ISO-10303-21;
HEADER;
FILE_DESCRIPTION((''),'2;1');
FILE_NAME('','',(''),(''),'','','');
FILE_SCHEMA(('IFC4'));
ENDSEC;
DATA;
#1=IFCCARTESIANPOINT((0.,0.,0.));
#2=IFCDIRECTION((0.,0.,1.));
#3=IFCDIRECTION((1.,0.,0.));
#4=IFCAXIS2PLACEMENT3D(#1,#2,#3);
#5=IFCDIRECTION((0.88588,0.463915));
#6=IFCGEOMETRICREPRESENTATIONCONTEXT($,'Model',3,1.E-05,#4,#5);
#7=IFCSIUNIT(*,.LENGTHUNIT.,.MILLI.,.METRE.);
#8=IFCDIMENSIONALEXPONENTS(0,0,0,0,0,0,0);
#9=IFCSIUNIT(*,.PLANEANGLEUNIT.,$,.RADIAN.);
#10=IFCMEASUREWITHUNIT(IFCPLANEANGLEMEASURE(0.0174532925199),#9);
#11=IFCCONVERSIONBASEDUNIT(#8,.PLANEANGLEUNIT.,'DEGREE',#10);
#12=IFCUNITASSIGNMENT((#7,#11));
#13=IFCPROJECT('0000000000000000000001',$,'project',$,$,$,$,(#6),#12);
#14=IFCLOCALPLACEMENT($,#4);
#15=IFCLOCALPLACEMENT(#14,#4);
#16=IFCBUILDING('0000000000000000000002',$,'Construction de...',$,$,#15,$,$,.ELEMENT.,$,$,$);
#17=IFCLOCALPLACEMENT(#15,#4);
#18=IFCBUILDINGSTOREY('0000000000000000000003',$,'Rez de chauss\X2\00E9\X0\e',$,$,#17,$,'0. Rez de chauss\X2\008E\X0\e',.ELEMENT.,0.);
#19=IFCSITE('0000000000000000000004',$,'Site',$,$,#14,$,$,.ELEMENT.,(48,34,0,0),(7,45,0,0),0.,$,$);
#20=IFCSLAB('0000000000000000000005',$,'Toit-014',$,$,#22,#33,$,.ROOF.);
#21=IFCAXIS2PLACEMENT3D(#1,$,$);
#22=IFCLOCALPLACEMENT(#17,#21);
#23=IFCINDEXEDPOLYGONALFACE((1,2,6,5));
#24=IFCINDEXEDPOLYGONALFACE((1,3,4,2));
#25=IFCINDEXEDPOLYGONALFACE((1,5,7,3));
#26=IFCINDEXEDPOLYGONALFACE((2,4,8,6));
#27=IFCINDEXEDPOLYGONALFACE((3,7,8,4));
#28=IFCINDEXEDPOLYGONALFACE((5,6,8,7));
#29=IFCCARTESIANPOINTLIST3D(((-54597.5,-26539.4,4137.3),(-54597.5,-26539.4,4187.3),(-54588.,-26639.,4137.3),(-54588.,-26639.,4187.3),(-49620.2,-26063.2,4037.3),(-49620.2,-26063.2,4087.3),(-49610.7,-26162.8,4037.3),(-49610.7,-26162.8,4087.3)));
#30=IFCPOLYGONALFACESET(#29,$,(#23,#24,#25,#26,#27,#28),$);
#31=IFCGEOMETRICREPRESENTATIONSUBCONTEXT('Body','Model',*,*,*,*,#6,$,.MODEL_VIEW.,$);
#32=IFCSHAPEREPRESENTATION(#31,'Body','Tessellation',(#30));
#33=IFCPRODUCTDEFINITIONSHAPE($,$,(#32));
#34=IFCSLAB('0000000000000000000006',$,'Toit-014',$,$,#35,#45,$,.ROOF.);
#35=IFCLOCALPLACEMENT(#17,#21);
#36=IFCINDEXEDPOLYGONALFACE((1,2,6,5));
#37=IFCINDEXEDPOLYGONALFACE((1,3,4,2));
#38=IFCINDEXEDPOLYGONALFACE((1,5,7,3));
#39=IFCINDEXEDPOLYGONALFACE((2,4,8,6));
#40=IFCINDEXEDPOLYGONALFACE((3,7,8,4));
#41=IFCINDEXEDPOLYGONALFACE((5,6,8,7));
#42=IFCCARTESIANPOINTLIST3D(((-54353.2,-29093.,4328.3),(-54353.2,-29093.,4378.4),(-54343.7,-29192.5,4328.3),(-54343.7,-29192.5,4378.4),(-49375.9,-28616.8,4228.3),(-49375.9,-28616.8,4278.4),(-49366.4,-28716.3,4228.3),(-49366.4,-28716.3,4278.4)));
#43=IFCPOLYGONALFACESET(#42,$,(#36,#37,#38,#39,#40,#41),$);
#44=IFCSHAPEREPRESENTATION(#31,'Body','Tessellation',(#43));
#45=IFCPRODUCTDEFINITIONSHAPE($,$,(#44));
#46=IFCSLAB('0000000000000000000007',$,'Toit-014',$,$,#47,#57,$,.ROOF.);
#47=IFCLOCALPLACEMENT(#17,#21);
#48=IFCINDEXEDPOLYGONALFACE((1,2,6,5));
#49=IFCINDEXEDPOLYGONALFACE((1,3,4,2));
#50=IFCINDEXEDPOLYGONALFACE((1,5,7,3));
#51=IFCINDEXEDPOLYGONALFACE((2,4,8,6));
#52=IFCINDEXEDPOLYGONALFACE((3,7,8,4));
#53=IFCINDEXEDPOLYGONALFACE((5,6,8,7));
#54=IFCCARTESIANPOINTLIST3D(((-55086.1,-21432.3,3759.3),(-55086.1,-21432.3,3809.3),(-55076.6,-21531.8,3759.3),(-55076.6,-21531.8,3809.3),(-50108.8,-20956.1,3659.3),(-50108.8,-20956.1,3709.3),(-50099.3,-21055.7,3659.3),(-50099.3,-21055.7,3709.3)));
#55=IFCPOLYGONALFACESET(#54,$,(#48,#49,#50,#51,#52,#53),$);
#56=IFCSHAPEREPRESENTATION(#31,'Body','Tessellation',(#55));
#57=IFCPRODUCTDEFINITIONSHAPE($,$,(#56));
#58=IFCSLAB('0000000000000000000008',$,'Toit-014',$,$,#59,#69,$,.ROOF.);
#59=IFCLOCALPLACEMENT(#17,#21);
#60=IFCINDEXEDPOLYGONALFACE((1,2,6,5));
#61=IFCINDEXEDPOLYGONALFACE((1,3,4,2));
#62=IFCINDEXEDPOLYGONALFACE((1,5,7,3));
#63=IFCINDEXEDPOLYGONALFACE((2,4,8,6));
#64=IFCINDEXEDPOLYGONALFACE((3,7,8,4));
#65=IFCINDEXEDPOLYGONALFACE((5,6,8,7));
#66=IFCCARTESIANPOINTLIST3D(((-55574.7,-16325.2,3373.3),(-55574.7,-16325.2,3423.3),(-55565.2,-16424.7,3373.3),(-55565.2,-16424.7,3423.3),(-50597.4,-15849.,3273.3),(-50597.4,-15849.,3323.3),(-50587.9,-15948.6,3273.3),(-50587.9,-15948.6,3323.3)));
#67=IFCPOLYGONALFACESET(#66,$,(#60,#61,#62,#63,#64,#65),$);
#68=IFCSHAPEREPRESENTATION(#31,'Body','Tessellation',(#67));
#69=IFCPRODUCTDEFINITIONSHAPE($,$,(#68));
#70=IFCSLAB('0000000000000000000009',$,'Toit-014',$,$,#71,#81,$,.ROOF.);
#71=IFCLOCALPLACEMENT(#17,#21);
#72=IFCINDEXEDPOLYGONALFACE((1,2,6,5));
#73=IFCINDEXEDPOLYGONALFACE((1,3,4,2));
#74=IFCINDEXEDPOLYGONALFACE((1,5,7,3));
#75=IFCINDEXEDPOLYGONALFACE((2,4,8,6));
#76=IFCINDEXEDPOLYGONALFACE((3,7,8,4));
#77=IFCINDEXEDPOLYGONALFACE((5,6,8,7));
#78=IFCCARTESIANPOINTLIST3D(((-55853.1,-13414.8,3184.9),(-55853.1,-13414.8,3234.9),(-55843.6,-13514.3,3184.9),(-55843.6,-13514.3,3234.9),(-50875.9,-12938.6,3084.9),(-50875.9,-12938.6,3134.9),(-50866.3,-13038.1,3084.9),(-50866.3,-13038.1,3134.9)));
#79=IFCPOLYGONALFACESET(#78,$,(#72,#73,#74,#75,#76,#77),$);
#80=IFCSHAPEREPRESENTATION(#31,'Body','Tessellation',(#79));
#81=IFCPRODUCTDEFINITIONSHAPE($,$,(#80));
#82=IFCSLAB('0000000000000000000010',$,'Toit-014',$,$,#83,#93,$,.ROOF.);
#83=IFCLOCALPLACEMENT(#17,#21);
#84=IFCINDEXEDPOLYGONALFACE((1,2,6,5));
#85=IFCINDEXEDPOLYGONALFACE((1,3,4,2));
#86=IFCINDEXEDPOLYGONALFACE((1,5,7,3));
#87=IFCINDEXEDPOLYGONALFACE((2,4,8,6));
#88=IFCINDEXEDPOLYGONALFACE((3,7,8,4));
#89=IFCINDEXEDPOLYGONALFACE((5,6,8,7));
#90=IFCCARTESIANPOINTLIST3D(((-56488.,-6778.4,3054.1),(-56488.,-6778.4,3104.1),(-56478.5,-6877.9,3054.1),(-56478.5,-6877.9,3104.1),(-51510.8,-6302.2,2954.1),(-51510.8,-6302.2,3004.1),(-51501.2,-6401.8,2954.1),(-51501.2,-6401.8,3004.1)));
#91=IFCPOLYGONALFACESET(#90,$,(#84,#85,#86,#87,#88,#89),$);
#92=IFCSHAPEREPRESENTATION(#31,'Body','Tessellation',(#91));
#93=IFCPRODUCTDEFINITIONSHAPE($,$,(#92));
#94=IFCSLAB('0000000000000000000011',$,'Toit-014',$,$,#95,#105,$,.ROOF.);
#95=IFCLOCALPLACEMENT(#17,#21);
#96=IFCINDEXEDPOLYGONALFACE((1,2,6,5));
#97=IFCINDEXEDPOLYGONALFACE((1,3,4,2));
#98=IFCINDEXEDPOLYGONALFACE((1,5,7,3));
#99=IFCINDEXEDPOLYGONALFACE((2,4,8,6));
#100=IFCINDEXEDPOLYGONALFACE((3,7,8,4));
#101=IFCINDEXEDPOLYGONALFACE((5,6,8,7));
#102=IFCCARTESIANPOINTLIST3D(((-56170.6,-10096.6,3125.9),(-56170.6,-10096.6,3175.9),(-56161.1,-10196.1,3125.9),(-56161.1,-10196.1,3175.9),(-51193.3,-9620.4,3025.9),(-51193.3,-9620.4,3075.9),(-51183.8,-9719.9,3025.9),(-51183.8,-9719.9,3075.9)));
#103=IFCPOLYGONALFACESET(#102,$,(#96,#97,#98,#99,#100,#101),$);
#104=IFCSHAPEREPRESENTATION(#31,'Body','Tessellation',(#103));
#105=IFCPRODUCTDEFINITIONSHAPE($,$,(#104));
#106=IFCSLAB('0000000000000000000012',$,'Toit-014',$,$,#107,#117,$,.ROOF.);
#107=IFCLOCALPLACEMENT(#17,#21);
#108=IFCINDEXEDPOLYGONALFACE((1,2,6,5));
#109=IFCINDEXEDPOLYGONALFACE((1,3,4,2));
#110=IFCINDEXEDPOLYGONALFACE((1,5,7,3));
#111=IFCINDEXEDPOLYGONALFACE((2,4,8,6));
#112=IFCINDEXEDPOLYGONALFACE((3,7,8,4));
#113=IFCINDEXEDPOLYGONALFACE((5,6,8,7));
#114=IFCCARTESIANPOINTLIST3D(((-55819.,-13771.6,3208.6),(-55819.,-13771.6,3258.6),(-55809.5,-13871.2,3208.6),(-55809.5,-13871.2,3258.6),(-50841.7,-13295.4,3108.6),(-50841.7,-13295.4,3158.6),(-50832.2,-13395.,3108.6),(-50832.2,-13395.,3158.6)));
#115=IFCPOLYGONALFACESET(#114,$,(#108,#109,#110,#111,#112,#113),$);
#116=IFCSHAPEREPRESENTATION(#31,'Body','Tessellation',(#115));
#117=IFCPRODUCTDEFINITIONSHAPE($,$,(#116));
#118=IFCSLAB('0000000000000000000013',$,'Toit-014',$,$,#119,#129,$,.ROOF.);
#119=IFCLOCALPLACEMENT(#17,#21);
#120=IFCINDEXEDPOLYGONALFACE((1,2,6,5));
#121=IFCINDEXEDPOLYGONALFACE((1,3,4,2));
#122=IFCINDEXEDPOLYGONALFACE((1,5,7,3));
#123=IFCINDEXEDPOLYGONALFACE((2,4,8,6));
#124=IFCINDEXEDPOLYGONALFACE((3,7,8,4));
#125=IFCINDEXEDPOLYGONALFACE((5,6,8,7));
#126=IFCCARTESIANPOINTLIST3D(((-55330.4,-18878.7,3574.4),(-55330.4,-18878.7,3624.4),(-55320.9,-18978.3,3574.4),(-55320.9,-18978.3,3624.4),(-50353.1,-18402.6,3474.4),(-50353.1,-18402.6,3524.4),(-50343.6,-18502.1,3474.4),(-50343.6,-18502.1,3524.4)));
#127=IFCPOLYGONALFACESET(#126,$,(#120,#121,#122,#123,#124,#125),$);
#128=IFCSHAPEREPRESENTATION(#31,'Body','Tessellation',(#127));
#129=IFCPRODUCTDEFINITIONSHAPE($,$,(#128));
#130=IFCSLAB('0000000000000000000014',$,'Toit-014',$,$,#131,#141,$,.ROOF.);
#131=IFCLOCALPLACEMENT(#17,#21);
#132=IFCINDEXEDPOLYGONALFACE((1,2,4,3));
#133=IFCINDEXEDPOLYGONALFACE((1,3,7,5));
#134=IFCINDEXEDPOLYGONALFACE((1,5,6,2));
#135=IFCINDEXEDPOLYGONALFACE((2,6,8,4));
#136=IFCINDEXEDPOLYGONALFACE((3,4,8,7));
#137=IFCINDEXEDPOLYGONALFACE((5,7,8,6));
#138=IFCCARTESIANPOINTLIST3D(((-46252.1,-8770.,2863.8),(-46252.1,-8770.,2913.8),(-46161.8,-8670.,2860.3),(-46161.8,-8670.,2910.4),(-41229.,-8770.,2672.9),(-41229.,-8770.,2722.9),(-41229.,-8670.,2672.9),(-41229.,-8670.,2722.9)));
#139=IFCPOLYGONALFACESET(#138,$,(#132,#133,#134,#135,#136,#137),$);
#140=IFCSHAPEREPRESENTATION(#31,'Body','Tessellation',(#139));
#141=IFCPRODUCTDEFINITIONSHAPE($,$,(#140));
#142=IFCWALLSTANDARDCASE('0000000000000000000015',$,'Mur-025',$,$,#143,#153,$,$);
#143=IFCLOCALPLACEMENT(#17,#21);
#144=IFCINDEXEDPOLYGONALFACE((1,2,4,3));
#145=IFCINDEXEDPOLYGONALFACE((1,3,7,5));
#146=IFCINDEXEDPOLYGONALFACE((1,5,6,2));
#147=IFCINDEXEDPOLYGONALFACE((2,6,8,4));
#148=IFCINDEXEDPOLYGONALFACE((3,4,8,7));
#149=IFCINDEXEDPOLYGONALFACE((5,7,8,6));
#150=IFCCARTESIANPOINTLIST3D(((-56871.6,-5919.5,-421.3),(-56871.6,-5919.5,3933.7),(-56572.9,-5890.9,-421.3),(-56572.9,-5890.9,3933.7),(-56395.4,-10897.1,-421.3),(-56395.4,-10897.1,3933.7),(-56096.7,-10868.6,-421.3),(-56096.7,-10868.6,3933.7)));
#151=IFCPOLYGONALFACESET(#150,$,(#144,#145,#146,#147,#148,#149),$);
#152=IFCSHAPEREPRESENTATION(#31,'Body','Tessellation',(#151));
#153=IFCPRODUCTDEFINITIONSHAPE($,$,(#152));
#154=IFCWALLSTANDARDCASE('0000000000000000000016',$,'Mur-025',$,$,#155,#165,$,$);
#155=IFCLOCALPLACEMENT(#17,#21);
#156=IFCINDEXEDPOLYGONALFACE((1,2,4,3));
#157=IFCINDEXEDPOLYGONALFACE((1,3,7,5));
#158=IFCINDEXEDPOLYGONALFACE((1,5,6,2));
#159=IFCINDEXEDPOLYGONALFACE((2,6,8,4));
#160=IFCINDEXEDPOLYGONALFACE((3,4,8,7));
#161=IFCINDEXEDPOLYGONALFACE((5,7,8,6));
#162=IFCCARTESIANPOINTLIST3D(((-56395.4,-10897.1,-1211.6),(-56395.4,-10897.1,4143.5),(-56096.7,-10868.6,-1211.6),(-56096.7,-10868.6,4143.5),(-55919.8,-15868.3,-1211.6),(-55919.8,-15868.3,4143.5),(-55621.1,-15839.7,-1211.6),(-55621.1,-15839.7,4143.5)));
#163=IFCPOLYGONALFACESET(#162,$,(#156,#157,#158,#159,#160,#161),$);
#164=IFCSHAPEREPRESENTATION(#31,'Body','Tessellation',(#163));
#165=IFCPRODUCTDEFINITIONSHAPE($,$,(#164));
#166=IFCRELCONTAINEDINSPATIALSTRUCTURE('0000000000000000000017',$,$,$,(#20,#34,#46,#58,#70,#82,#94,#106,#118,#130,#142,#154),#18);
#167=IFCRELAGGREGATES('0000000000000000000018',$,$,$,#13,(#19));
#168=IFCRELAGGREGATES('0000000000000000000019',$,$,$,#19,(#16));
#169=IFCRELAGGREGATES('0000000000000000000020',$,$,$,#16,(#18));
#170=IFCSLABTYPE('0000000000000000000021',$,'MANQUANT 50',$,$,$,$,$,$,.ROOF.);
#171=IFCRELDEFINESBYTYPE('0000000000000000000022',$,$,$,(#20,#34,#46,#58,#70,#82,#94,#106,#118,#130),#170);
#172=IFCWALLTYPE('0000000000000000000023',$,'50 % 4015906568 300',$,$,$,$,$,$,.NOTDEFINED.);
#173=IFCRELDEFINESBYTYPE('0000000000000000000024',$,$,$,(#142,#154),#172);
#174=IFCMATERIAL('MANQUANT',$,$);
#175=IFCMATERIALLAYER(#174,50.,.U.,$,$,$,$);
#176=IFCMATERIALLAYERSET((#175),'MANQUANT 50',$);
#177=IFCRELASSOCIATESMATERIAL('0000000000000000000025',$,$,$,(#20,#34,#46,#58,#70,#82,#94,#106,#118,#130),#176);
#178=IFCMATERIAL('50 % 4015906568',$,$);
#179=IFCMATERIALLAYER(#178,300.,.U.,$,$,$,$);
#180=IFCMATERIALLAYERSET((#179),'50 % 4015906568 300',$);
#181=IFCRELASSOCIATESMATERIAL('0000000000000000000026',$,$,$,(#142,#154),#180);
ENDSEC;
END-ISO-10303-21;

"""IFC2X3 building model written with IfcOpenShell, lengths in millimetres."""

from ifc_helpers import new_model, entity, si_unit, converted_unit, direction, frame, origin_with_axes, place, context, subcontext, project, spatial, polyline, outline, extrude, material, layer, layer_set, layer_usage, type_object, element, save


model = new_model("IFC2X3")

# Units and contexts
model_context = context("Model", 3, precision=1e-05, world=origin_with_axes(), true_north=direction((0.88588, 0.463915)))
body_context = subcontext(model_context, "Body", "Model", "MODEL_VIEW")
ifc_project = project(units=[si_unit("LENGTHUNIT", "METRE", prefix="MILLI"), converted_unit("PLANEANGLEUNIT", "DEGREE", entity("IfcPlaneAngleMeasure", 0.0174532925199), si_unit("PLANEANGLEUNIT", "RADIAN"), dimensions=[0, 0, 0, 0, 0, 0, 0])], contexts=[model_context])

# Site, building, storey
site_placement = place(None, origin_with_axes())
site = spatial("IfcSite", under=ifc_project, at=site_placement, Name="Site", CompositionType="ELEMENT", RefLatitude=(48, 34, 0, 0), RefLongitude=(7, 45, 0, 0), RefElevation=0.0)
building_placement = place(site_placement, origin_with_axes())
building = spatial("IfcBuilding", under=site, at=building_placement, Name="Construction de...", CompositionType="ELEMENT")
storey_placement = place(building_placement, origin_with_axes())
storey = spatial("IfcBuildingStorey", under=building, at=storey_placement, Name="Rez de chaussée", LongName="0. Rez de chauss\u008ee", CompositionType="ELEMENT", Elevation=0.0)

# Slabs
ifc_material_1 = material(Name="MANQUANT")
ifc_layer_1 = layer(ifc_material_1, 50.0, ventilated="UNKNOWN")
ifc_layer_set_1 = layer_set([ifc_layer_1], Name="MANQUANT 50")
slab_type_1 = type_object("IfcSlabType", Name="MANQUANT 50", PredefinedType="ROOF")
ifc_layer_usage_1 = layer_usage(ifc_layer_set_1, "AXIS3", "NEGATIVE", 50.0)
slab_1_placement = place(storey_placement, frame((-49610.7, -26162.8, 4037.3), z_axis=(0.0, 0.0, 1.0), x_axis=(-0.095235, 0.995455, 0.0)))
element("IfcSlab", 1, at=slab_1_placement, inside=storey, type_object=slab_type_1, material=ifc_layer_usage_1, Name="Toit-014", PredefinedType="ROOF", context=body_context, shape_type="SweptSolid", body=[
    extrude(outline(polyline([(0.0, 0.0), (100.0, 0.0), (100.0, 5001.0), (0.0, 5001.0), (0.0, 0.0)])), frame((0.0, 0.0, 0.0), z_axis=(0.0, -0.019996, 0.9998), x_axis=(1.0, 0.0, 0.0)), (0.0, 0.019996, 0.9998), 50.0),
])
ifc_layer_usage_2 = layer_usage(ifc_layer_set_1, "AXIS3", "NEGATIVE", 50.0)
slab_2_placement = place(storey_placement, frame((-49366.4, -28716.3, 4228.3), z_axis=(0.0, 0.0, 1.0), x_axis=(-0.095235, 0.995455, 0.0)))
element("IfcSlab", 2, at=slab_2_placement, inside=storey, type_object=slab_type_1, material=ifc_layer_usage_2, Name="Toit-014", PredefinedType="ROOF", context=body_context, shape_type="SweptSolid", body=[
    extrude(outline(polyline([(0.0, 0.0), (100.0, 0.0), (100.0, 5001.0), (0.0, 5001.0), (0.0, 0.0)])), frame((0.0, 0.0, 0.0), z_axis=(0.0, -0.019996, 0.9998), x_axis=(1.0, 0.0, 0.0)), (0.0, 0.019996, 0.9998), 50.0),
])
ifc_layer_usage_3 = layer_usage(ifc_layer_set_1, "AXIS3", "NEGATIVE", 50.0)
slab_3_placement = place(storey_placement, frame((-50099.3, -21055.7, 3659.3), z_axis=(0.0, 0.0, 1.0), x_axis=(-0.095235, 0.995455, 0.0)))
element("IfcSlab", 3, at=slab_3_placement, inside=storey, type_object=slab_type_1, material=ifc_layer_usage_3, Name="Toit-014", PredefinedType="ROOF", context=body_context, shape_type="SweptSolid", body=[
    extrude(outline(polyline([(0.0, 0.0), (100.0, 0.0), (100.0, 5001.0), (0.0, 5001.0), (0.0, 0.0)])), frame((0.0, 0.0, 0.0), z_axis=(0.0, -0.019996, 0.9998), x_axis=(1.0, 0.0, 0.0)), (0.0, 0.019996, 0.9998), 50.0),
])
ifc_layer_usage_4 = layer_usage(ifc_layer_set_1, "AXIS3", "NEGATIVE", 50.0)
slab_4_placement = place(storey_placement, frame((-50587.9, -15948.6, 3273.3), z_axis=(0.0, 0.0, 1.0), x_axis=(-0.095235, 0.995455, 0.0)))
element("IfcSlab", 4, at=slab_4_placement, inside=storey, type_object=slab_type_1, material=ifc_layer_usage_4, Name="Toit-014", PredefinedType="ROOF", context=body_context, shape_type="SweptSolid", body=[
    extrude(outline(polyline([(0.0, 0.0), (100.0, 0.0), (100.0, 5001.0), (0.0, 5001.0), (0.0, 0.0)])), frame((0.0, 0.0, 0.0), z_axis=(0.0, -0.019996, 0.9998), x_axis=(1.0, 0.0, 0.0)), (0.0, 0.019996, 0.9998), 50.0),
])
ifc_layer_usage_5 = layer_usage(ifc_layer_set_1, "AXIS3", "NEGATIVE", 50.0)
slab_5_placement = place(storey_placement, frame((-50866.3, -13038.1, 3084.9), z_axis=(0.0, 0.0, 1.0), x_axis=(-0.095235, 0.995455, 0.0)))
element("IfcSlab", 5, at=slab_5_placement, inside=storey, type_object=slab_type_1, material=ifc_layer_usage_5, Name="Toit-014", PredefinedType="ROOF", context=body_context, shape_type="SweptSolid", body=[
    extrude(outline(polyline([(0.0, 0.0), (100.0, 0.0), (100.0, 5001.0), (0.0, 5001.0), (0.0, 0.0)])), frame((0.0, 0.0, 0.0), z_axis=(0.0, -0.019996, 0.9998), x_axis=(1.0, 0.0, 0.0)), (0.0, 0.019996, 0.9998), 50.0),
])
ifc_layer_usage_6 = layer_usage(ifc_layer_set_1, "AXIS3", "NEGATIVE", 50.0)
slab_6_placement = place(storey_placement, frame((-51501.2, -6401.8, 2954.1), z_axis=(0.0, 0.0, 1.0), x_axis=(-0.095235, 0.995455, 0.0)))
element("IfcSlab", 6, at=slab_6_placement, inside=storey, type_object=slab_type_1, material=ifc_layer_usage_6, Name="Toit-014", PredefinedType="ROOF", context=body_context, shape_type="SweptSolid", body=[
    extrude(outline(polyline([(0.0, 0.0), (100.0, 0.0), (100.0, 5001.0), (0.0, 5001.0), (0.0, 0.0)])), frame((0.0, 0.0, 0.0), z_axis=(0.0, -0.019996, 0.9998), x_axis=(1.0, 0.0, 0.0)), (0.0, 0.019996, 0.9998), 50.0),
])
ifc_layer_usage_7 = layer_usage(ifc_layer_set_1, "AXIS3", "NEGATIVE", 50.0)
slab_7_placement = place(storey_placement, frame((-51183.8, -9719.9, 3025.9), z_axis=(0.0, 0.0, 1.0), x_axis=(-0.095235, 0.995455, 0.0)))
element("IfcSlab", 7, at=slab_7_placement, inside=storey, type_object=slab_type_1, material=ifc_layer_usage_7, Name="Toit-014", PredefinedType="ROOF", context=body_context, shape_type="SweptSolid", body=[
    extrude(outline(polyline([(0.0, 0.0), (100.0, 0.0), (100.0, 5001.0), (0.0, 5001.0), (0.0, 0.0)])), frame((0.0, 0.0, 0.0), z_axis=(0.0, -0.019996, 0.9998), x_axis=(1.0, 0.0, 0.0)), (0.0, 0.019996, 0.9998), 50.0),
])
ifc_layer_usage_8 = layer_usage(ifc_layer_set_1, "AXIS3", "NEGATIVE", 50.0)
slab_8_placement = place(storey_placement, frame((-50832.2, -13395.0, 3108.6), z_axis=(0.0, 0.0, 1.0), x_axis=(-0.095235, 0.995455, 0.0)))
element("IfcSlab", 8, at=slab_8_placement, inside=storey, type_object=slab_type_1, material=ifc_layer_usage_8, Name="Toit-014", PredefinedType="ROOF", context=body_context, shape_type="SweptSolid", body=[
    extrude(outline(polyline([(0.0, 0.0), (100.0, 0.0), (100.0, 5001.0), (0.0, 5001.0), (0.0, 0.0)])), frame((0.0, 0.0, 0.0), z_axis=(0.0, -0.019996, 0.9998), x_axis=(1.0, 0.0, 0.0)), (0.0, 0.019996, 0.9998), 50.0),
])
ifc_layer_usage_9 = layer_usage(ifc_layer_set_1, "AXIS3", "NEGATIVE", 50.0)
slab_9_placement = place(storey_placement, frame((-50343.6, -18502.1, 3474.4), z_axis=(0.0, 0.0, 1.0), x_axis=(-0.095235, 0.995455, 0.0)))
element("IfcSlab", 9, at=slab_9_placement, inside=storey, type_object=slab_type_1, material=ifc_layer_usage_9, Name="Toit-014", PredefinedType="ROOF", context=body_context, shape_type="SweptSolid", body=[
    extrude(outline(polyline([(0.0, 0.0), (100.0, 0.0), (100.0, 5001.0), (0.0, 5001.0), (0.0, 0.0)])), frame((0.0, 0.0, 0.0), z_axis=(0.0, -0.019996, 0.9998), x_axis=(1.0, 0.0, 0.0)), (0.0, 0.019996, 0.9998), 50.0),
])
ifc_layer_usage_10 = layer_usage(ifc_layer_set_1, "AXIS3", "NEGATIVE", 50.0)
slab_10_placement = place(storey_placement, frame((-41229.0, -8770.0, 2672.9), z_axis=(0.0, 0.0, 1.0), x_axis=(0.0, 1.0, 0.0)))
element("IfcSlab", 10, at=slab_10_placement, inside=storey, type_object=slab_type_1, material=ifc_layer_usage_10, Name="Toit-014", PredefinedType="ROOF", context=body_context, shape_type="SweptSolid", body=[
    extrude(outline(polyline([(0.0, 0.0), (100.0, 0.0), (100.0, 4936.4), (0.0, 5026.7), (0.0, 0.0)])), frame((0.0, 0.0, 0.0), z_axis=(0.0, -0.037973, 0.999279), x_axis=(1.0, 0.0, 0.0)), (0.0, 0.037973, 0.999279), 50.0),
])

# Walls
ifc_material_2 = material(Name="50 % 4015906568")
ifc_layer_2 = layer(ifc_material_2, 300.0, ventilated="UNKNOWN")
ifc_layer_set_2 = layer_set([ifc_layer_2], Name="50 % 4015906568 300")
ifc_layer_usage_11 = layer_usage(ifc_layer_set_2, "AXIS2", "NEGATIVE", 150.0)
wall_type_1 = type_object("IfcWallType", Name="50 % 4015906568 300", PredefinedType="NOTDEFINED")
wall_1_placement = place(storey_placement, frame((-56722.3, -5905.2, -421.3), z_axis=(0.0, 0.0, 1.0), x_axis=(0.095235, -0.995455, 0.0)))
element("IfcWallStandardCase", 11, at=wall_1_placement, inside=storey, type_object=wall_type_1, material=ifc_layer_usage_11, Name="Mur-025", context=body_context, shape_type="SweptSolid", body=[
    extrude(outline(polyline([(0.0, -150.0), (5000.3, -150.0), (5000.3, 150.0), (0.0, 150.0), (0.0, -150.0)])), origin_with_axes(), (0.0, 0.0, 1.0), 4355.0),
])
ifc_layer_usage_12 = layer_usage(ifc_layer_set_2, "AXIS2", "NEGATIVE", 150.0)
wall_2_placement = place(storey_placement, frame((-56246.0, -10882.8, -1211.6), z_axis=(0.0, 0.0, 1.0), x_axis=(0.095235, -0.995455, 0.0)))
element("IfcWallStandardCase", 12, at=wall_2_placement, inside=storey, type_object=wall_type_1, material=ifc_layer_usage_12, Name="Mur-025", context=body_context, shape_type="SweptSolid", body=[
    extrude(outline(polyline([(0.0, -150.0), (4993.8, -150.0), (4993.8, 150.0), (0.0, 150.0), (0.0, -150.0)])), origin_with_axes(), (0.0, 0.0, 1.0), 5355.0),
])

save(model, "model.ifc")
